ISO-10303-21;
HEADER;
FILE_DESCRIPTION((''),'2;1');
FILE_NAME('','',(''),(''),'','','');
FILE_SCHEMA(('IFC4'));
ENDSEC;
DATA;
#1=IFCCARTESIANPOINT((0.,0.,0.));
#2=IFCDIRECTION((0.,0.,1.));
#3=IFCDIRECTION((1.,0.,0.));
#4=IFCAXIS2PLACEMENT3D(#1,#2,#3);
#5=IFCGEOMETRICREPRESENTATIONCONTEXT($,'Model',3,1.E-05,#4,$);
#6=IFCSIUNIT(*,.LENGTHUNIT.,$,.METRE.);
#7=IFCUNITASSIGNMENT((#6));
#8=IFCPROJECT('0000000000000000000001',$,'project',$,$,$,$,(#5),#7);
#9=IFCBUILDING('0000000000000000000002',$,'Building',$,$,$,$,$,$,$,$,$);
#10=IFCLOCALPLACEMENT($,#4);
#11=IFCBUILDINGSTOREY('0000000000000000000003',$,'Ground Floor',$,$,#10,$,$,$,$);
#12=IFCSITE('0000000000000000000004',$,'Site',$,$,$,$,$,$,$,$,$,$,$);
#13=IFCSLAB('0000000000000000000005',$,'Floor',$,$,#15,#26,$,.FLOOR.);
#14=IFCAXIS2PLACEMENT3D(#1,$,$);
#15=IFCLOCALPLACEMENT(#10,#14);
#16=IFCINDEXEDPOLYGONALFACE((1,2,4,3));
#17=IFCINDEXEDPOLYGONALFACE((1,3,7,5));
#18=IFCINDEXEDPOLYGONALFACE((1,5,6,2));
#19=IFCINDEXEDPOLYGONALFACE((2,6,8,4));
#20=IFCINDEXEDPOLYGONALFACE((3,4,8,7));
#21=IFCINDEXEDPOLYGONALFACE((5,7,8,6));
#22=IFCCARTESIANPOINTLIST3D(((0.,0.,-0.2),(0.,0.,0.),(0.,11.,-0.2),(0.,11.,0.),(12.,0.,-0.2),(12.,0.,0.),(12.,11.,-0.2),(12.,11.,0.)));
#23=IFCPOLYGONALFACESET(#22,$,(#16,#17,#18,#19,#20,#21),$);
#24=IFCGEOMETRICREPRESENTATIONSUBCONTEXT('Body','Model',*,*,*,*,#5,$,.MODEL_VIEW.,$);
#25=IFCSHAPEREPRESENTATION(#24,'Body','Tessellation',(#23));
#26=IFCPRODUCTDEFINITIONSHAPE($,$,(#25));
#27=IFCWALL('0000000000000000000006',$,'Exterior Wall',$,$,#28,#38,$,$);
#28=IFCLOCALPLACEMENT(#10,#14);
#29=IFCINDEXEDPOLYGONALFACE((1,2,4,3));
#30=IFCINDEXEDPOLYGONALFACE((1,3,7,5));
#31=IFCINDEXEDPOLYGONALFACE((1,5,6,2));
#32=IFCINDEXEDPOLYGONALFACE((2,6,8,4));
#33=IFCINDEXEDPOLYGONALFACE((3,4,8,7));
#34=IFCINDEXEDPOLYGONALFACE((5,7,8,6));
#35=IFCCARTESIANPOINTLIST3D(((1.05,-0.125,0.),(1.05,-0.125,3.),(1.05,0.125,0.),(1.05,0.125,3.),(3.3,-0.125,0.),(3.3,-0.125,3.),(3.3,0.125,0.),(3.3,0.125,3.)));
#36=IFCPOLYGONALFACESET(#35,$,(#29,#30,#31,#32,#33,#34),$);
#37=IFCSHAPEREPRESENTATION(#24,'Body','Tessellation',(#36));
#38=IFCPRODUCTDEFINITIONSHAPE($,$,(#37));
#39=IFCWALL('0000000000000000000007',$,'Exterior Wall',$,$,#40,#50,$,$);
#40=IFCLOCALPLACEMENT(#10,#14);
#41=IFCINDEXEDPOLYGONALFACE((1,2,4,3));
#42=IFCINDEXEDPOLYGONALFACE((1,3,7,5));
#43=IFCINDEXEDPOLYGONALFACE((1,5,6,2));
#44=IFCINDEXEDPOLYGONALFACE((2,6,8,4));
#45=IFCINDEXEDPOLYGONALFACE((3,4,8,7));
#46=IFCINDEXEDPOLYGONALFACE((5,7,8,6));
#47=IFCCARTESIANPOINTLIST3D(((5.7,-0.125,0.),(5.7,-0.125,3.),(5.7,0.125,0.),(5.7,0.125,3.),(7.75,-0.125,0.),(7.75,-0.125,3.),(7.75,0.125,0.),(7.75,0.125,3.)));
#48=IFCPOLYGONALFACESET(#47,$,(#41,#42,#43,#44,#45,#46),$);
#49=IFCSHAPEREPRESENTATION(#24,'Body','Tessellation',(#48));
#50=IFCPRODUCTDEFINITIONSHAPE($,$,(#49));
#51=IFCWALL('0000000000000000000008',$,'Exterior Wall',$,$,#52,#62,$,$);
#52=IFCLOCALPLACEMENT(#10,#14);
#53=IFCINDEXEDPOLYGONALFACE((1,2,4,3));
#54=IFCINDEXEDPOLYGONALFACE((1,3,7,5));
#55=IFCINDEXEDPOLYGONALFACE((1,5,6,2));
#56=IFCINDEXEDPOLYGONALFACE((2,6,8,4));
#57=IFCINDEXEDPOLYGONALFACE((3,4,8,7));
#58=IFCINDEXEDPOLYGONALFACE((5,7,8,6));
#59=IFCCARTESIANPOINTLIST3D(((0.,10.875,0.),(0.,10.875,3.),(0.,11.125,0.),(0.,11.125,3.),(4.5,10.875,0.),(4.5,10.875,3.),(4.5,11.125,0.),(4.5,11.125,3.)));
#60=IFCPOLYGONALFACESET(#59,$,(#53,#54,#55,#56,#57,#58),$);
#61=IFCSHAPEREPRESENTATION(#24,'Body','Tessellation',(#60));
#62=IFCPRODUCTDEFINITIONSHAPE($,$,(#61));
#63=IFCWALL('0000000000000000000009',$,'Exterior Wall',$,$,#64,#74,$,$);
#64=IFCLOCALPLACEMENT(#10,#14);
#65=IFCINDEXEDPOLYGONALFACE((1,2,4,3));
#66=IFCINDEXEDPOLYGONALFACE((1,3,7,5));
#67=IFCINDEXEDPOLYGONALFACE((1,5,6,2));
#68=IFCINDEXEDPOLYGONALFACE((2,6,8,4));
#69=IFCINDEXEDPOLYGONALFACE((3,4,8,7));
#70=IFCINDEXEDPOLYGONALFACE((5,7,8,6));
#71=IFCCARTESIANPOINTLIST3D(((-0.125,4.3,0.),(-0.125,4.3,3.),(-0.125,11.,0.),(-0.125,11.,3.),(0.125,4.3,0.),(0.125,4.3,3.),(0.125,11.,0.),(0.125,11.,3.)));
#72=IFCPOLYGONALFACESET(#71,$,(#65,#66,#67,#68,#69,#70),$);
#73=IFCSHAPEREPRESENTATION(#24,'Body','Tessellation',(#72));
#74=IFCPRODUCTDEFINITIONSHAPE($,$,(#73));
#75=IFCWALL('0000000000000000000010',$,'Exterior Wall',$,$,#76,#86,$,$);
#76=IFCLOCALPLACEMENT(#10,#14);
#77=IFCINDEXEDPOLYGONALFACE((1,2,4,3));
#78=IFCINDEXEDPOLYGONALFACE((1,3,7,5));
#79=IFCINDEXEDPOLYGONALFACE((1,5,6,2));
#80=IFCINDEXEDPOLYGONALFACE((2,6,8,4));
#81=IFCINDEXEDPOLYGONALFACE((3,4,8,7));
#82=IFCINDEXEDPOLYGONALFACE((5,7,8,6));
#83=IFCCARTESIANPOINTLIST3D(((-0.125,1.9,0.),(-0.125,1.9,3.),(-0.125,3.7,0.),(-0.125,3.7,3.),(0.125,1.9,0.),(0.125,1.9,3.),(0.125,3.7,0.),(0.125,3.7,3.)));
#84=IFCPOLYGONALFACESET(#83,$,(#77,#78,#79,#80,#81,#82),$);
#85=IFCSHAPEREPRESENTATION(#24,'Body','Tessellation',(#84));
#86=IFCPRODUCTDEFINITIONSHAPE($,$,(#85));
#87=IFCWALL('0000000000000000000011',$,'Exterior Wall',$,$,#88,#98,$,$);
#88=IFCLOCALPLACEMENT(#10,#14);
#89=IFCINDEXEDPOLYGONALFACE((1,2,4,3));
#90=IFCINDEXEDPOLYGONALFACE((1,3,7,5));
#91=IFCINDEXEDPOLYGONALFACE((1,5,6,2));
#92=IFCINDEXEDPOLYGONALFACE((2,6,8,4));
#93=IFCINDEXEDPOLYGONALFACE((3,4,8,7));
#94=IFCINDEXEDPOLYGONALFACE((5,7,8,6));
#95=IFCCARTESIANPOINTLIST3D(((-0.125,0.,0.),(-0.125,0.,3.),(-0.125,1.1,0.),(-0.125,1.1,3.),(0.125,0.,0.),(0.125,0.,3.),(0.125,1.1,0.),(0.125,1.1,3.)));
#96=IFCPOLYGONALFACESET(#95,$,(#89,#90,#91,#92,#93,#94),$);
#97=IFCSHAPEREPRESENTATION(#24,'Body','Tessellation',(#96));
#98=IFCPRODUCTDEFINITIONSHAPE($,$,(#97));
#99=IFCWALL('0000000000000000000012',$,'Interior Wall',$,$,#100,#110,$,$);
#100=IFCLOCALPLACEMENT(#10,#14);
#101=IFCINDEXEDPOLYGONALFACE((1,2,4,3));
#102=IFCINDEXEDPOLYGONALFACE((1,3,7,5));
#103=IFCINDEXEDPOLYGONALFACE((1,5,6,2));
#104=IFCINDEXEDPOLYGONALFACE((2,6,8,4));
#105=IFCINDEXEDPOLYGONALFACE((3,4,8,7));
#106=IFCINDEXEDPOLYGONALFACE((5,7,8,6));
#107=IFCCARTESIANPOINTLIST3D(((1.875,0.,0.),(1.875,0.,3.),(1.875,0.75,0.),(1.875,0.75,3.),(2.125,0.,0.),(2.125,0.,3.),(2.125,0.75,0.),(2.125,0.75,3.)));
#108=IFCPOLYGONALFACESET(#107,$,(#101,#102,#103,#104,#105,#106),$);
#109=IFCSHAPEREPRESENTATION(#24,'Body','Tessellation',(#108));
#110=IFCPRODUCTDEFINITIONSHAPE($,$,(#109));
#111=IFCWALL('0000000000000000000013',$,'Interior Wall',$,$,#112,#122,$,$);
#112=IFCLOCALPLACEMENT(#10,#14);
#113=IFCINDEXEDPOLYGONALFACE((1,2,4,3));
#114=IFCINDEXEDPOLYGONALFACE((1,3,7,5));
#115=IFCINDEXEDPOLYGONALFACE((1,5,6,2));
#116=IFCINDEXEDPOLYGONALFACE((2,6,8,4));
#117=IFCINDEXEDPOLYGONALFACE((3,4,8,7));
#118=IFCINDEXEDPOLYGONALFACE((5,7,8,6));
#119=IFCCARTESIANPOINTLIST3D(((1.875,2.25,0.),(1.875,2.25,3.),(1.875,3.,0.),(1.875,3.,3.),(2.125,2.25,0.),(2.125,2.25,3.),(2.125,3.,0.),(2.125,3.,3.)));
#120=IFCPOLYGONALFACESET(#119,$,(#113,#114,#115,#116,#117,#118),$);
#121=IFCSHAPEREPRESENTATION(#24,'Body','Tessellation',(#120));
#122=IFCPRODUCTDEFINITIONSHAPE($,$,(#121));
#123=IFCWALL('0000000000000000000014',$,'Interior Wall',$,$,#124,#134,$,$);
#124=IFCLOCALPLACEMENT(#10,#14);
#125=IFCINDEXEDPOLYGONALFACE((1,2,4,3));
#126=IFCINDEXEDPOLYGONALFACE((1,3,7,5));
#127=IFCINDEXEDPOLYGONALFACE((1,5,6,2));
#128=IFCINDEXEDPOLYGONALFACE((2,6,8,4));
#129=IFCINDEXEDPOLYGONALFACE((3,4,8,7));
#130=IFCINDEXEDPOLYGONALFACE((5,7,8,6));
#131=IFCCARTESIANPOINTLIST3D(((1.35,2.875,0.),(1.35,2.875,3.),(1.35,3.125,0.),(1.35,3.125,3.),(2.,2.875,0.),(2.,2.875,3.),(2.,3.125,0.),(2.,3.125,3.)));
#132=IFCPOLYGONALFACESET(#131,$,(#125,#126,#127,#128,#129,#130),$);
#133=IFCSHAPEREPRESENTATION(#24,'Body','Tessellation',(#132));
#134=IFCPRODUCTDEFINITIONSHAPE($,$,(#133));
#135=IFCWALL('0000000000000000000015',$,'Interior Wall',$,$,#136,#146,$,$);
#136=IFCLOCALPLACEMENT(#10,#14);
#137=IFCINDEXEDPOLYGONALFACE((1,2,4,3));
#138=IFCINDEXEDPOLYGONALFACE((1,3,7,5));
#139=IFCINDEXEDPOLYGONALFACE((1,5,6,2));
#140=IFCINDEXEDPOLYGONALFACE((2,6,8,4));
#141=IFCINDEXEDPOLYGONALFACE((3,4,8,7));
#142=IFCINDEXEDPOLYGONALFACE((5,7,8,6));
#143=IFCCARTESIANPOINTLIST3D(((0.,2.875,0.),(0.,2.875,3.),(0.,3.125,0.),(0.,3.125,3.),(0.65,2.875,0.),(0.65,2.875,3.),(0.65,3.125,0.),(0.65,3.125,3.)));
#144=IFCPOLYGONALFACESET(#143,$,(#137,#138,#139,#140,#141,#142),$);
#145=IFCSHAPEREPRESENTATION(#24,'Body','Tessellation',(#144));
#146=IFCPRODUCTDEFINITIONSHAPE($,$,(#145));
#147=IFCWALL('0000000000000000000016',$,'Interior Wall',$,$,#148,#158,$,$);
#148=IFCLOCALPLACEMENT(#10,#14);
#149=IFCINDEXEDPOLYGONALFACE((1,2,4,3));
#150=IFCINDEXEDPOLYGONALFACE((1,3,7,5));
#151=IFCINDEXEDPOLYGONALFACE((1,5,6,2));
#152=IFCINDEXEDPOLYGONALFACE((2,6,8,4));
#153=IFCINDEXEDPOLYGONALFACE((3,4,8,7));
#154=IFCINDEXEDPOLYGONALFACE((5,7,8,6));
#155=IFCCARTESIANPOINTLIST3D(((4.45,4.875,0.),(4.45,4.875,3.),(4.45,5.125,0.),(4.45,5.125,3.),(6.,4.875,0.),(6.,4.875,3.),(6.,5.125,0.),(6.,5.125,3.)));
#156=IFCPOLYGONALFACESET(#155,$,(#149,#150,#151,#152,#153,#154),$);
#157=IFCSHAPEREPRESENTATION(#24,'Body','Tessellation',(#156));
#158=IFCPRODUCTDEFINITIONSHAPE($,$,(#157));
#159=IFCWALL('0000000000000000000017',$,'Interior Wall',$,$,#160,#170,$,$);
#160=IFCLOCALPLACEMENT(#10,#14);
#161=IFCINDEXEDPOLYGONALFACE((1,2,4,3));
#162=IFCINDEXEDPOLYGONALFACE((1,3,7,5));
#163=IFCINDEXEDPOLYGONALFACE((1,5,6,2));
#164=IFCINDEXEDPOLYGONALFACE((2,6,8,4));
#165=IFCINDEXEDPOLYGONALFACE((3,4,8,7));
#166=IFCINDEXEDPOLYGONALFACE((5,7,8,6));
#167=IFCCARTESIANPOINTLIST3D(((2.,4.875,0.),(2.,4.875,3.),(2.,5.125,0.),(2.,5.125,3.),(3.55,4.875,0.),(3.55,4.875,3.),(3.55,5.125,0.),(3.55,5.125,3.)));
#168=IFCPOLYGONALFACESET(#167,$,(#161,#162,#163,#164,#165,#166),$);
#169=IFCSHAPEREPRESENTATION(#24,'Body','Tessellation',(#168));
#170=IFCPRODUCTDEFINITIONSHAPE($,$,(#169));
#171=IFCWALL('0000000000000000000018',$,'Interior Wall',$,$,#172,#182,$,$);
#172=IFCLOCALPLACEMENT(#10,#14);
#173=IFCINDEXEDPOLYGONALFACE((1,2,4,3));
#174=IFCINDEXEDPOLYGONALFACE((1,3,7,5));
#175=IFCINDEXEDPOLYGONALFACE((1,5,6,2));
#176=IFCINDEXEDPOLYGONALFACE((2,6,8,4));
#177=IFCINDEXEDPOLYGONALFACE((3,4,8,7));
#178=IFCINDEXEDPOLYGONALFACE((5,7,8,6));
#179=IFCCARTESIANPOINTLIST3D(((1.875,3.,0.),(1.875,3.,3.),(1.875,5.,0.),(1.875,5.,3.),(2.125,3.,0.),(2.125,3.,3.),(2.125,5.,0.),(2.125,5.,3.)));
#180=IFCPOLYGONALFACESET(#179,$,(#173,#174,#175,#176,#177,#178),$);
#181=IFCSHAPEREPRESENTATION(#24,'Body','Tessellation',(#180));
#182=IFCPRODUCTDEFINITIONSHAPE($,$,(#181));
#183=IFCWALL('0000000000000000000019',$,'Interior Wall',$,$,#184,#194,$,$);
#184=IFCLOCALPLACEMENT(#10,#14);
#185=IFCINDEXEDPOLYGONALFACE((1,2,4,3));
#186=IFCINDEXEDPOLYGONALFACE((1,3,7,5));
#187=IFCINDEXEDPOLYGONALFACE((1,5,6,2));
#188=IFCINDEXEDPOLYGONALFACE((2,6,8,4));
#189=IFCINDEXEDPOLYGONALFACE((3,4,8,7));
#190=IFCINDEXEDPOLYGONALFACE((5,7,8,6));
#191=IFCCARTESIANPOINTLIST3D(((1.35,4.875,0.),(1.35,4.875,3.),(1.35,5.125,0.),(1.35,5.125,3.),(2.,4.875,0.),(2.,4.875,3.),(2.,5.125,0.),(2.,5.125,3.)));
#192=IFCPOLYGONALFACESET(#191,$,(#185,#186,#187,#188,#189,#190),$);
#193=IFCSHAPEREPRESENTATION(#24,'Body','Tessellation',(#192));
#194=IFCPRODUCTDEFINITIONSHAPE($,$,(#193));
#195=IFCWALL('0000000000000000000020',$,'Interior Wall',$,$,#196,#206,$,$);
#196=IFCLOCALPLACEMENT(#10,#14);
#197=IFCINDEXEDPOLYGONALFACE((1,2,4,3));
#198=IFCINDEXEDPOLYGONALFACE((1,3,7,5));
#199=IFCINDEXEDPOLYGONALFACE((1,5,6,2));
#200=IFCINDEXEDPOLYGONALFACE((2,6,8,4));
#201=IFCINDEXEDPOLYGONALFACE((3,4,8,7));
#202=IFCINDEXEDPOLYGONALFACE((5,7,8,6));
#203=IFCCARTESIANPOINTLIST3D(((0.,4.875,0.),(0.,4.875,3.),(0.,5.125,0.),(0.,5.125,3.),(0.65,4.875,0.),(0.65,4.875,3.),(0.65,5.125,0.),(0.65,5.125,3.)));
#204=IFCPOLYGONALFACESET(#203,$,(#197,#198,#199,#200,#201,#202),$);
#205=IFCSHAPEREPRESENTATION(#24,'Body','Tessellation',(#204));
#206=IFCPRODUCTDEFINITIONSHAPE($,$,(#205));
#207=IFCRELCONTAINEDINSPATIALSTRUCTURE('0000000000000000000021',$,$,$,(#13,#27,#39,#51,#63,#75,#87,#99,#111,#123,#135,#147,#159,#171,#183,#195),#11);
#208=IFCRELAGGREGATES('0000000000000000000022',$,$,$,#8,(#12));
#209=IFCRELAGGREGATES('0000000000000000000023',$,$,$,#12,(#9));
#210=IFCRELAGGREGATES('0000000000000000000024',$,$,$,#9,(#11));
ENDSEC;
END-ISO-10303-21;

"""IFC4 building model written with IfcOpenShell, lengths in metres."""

from ifc_helpers import new_model, si_unit, frame, origin_with_axes, place, context, subcontext, project, spatial, indexed_curve, outline, extrude, element, save


model = new_model("IFC4")

# Units and contexts
model_context = context("Model", 3, precision=1e-05, world=origin_with_axes())
body_context = subcontext(model_context, "Body", "Model", "MODEL_VIEW")
ifc_project = project(units=[si_unit("LENGTHUNIT", "METRE")], contexts=[model_context])

# Site, building, storey
site = spatial("IfcSite", under=ifc_project, Name="Site")
building = spatial("IfcBuilding", under=site, Name="Building")
storey_placement = place(None, origin_with_axes())
storey = spatial("IfcBuildingStorey", under=building, at=storey_placement, Name="Ground Floor")

# Slab
slab_placement = place(storey_placement, frame((0.0, 0.0, -0.2), z_axis=(0.0, 0.0, 1.0), x_axis=(1.0, 0.0, 0.0)))
element("IfcSlab", 1, at=slab_placement, inside=storey, Name="Floor", PredefinedType="FLOOR", context=body_context, shape_type="SweptSolid", body=[
    extrude(outline(indexed_curve([(0.0, 0.0), (12.0, 0.0), (12.0, 11.0), (0.0, 11.0)])), None, (0.0, 0.0, 1.0), 0.2),
])

# Walls
wall_1_placement = place(storey_placement, frame((1.05, 0.0, 0.0), z_axis=(0.0, 0.0, 1.0), x_axis=(1.0, 0.0, 0.0)))
element("IfcWall", 2, at=wall_1_placement, inside=storey, Name="Exterior Wall", context=body_context, shape_type="SweptSolid", body=[
    extrude(outline(indexed_curve([(0.0, 0.0), (0.0, 0.25), (2.25, 0.25), (2.25, 0.0), (0.0, 0.0)], self_intersect=False)), frame((0.0, -0.125, 0.0), z_axis=(0.0, 0.0, 1.0), x_axis=(1.0, 0.0, 0.0)), (0.0, 0.0, 1.0), 3.0),
])
wall_2_placement = place(storey_placement, frame((5.7, 0.0, 0.0), z_axis=(0.0, 0.0, 1.0), x_axis=(1.0, 0.0, 0.0)))
element("IfcWall", 3, at=wall_2_placement, inside=storey, Name="Exterior Wall", context=body_context, shape_type="SweptSolid", body=[
    extrude(outline(indexed_curve([(0.0, 0.0), (0.0, 0.25), (2.05, 0.25), (2.05, 0.0), (0.0, 0.0)], self_intersect=False)), frame((0.0, -0.125, 0.0), z_axis=(0.0, 0.0, 1.0), x_axis=(1.0, 0.0, 0.0)), (0.0, 0.0, 1.0), 3.0),
])
wall_3_placement = place(storey_placement, frame((4.5, 11.0, 0.0), z_axis=(0.0, 0.0, 1.0), x_axis=(-1.0, 0.0, 0.0)))
element("IfcWall", 4, at=wall_3_placement, inside=storey, Name="Exterior Wall", context=body_context, shape_type="SweptSolid", body=[
    extrude(outline(indexed_curve([(0.0, 0.0), (0.0, 0.25), (4.5, 0.25), (4.5, 0.0), (0.0, 0.0)], self_intersect=False)), frame((0.0, -0.125, 0.0), z_axis=(0.0, 0.0, 1.0), x_axis=(1.0, 0.0, 0.0)), (0.0, 0.0, 1.0), 3.0),
])
wall_4_placement = place(storey_placement, frame((0.0, 11.0, 0.0), z_axis=(0.0, 0.0, 1.0), x_axis=(0.0, -1.0, 0.0)))
element("IfcWall", 5, at=wall_4_placement, inside=storey, Name="Exterior Wall", context=body_context, shape_type="SweptSolid", body=[
    extrude(outline(indexed_curve([(0.0, 0.0), (0.0, 0.25), (6.7, 0.25), (6.7, 0.0), (0.0, 0.0)], self_intersect=False)), frame((0.0, -0.125, 0.0), z_axis=(0.0, 0.0, 1.0), x_axis=(1.0, 0.0, 0.0)), (0.0, 0.0, 1.0), 3.0),
])
wall_5_placement = place(storey_placement, frame((0.0, 3.7, 0.0), z_axis=(0.0, 0.0, 1.0), x_axis=(0.0, -1.0, 0.0)))
element("IfcWall", 6, at=wall_5_placement, inside=storey, Name="Exterior Wall", context=body_context, shape_type="SweptSolid", body=[
    extrude(outline(indexed_curve([(0.0, 0.0), (0.0, 0.25), (1.8, 0.25), (1.8, 0.0), (0.0, 0.0)], self_intersect=False)), frame((0.0, -0.125, 0.0), z_axis=(0.0, 0.0, 1.0), x_axis=(1.0, 0.0, 0.0)), (0.0, 0.0, 1.0), 3.0),
])
wall_6_placement = place(storey_placement, frame((0.0, 1.1, 0.0), z_axis=(0.0, 0.0, 1.0), x_axis=(0.0, -1.0, 0.0)))
element("IfcWall", 7, at=wall_6_placement, inside=storey, Name="Exterior Wall", context=body_context, shape_type="SweptSolid", body=[
    extrude(outline(indexed_curve([(0.0, 0.0), (0.0, 0.25), (1.1, 0.25), (1.1, 0.0), (0.0, 0.0)], self_intersect=False)), frame((0.0, -0.125, 0.0), z_axis=(0.0, 0.0, 1.0), x_axis=(1.0, 0.0, 0.0)), (0.0, 0.0, 1.0), 3.0),
])
for number, where, z_axis, x_axis, name in (
    (8, (2.0, 0.0, 0.0), (0.0, 0.0, 1.0), (0.0, 1.0, 0.0), "Interior Wall"),
    (9, (2.0, 2.25, 0.0), (0.0, 0.0, 1.0), (0.0, 1.0, 0.0), "Interior Wall"),
):
    element("IfcWall", number, at=place(storey_placement, frame(where, z_axis=z_axis, x_axis=x_axis)), inside=storey, Name=name, context=body_context, shape_type="SweptSolid", body=[
        extrude(outline(indexed_curve([(0.0, 0.0), (0.0, 0.25), (0.75, 0.25), (0.75, 0.0), (0.0, 0.0)], self_intersect=False)), frame((0.0, -0.125, 0.0), z_axis=(0.0, 0.0, 1.0), x_axis=(1.0, 0.0, 0.0)), (0.0, 0.0, 1.0), 3.0),
    ])
for number, where, z_axis, x_axis, name in (
    (10, (2.0, 3.0, 0.0), (0.0, 0.0, 1.0), (-1.0, 0.0, 0.0), "Interior Wall"),
    (11, (0.65, 3.0, 0.0), (0.0, 0.0, 1.0), (-1.0, 0.0, 0.0), "Interior Wall"),
):
    element("IfcWall", number, at=place(storey_placement, frame(where, z_axis=z_axis, x_axis=x_axis)), inside=storey, Name=name, context=body_context, shape_type="SweptSolid", body=[
        extrude(outline(indexed_curve([(0.0, 0.0), (0.0, 0.25), (0.65, 0.25), (0.65, 0.0), (0.0, 0.0)], self_intersect=False)), frame((0.0, -0.125, 0.0), z_axis=(0.0, 0.0, 1.0), x_axis=(1.0, 0.0, 0.0)), (0.0, 0.0, 1.0), 3.0),
    ])
for number, where, z_axis, x_axis, name in (
    (12, (6.0, 5.0, 0.0), (0.0, 0.0, 1.0), (-1.0, 0.0, 0.0), "Interior Wall"),
    (13, (3.55, 5.0, 0.0), (0.0, 0.0, 1.0), (-1.0, 0.0, 0.0), "Interior Wall"),
):
    element("IfcWall", number, at=place(storey_placement, frame(where, z_axis=z_axis, x_axis=x_axis)), inside=storey, Name=name, context=body_context, shape_type="SweptSolid", body=[
        extrude(outline(indexed_curve([(0.0, 0.0), (0.0, 0.25), (1.55, 0.25), (1.55, 0.0), (0.0, 0.0)], self_intersect=False)), frame((0.0, -0.125, 0.0), z_axis=(0.0, 0.0, 1.0), x_axis=(1.0, 0.0, 0.0)), (0.0, 0.0, 1.0), 3.0),
    ])
wall_7_placement = place(storey_placement, frame((2.0, 5.0, 0.0), z_axis=(0.0, 0.0, 1.0), x_axis=(0.0, -1.0, 0.0)))
element("IfcWall", 14, at=wall_7_placement, inside=storey, Name="Interior Wall", context=body_context, shape_type="SweptSolid", body=[
    extrude(outline(indexed_curve([(0.0, 0.0), (0.0, 0.25), (2.0, 0.25), (2.0, 0.0), (0.0, 0.0)], self_intersect=False)), frame((0.0, -0.125, 0.0), z_axis=(0.0, 0.0, 1.0), x_axis=(1.0, 0.0, 0.0)), (0.0, 0.0, 1.0), 3.0),
])
for number, where, z_axis, x_axis, name in (
    (15, (2.0, 5.0, 0.0), (0.0, 0.0, 1.0), (-1.0, 0.0, 0.0), "Interior Wall"),
    (16, (0.65, 5.0, 0.0), (0.0, 0.0, 1.0), (-1.0, 0.0, 0.0), "Interior Wall"),
):
    element("IfcWall", number, at=place(storey_placement, frame(where, z_axis=z_axis, x_axis=x_axis)), inside=storey, Name=name, context=body_context, shape_type="SweptSolid", body=[
        extrude(outline(indexed_curve([(0.0, 0.0), (0.0, 0.25), (0.65, 0.25), (0.65, 0.0), (0.0, 0.0)], self_intersect=False)), frame((0.0, -0.125, 0.0), z_axis=(0.0, 0.0, 1.0), x_axis=(1.0, 0.0, 0.0)), (0.0, 0.0, 1.0), 3.0),
    ])

save(model, "model.ifc")
